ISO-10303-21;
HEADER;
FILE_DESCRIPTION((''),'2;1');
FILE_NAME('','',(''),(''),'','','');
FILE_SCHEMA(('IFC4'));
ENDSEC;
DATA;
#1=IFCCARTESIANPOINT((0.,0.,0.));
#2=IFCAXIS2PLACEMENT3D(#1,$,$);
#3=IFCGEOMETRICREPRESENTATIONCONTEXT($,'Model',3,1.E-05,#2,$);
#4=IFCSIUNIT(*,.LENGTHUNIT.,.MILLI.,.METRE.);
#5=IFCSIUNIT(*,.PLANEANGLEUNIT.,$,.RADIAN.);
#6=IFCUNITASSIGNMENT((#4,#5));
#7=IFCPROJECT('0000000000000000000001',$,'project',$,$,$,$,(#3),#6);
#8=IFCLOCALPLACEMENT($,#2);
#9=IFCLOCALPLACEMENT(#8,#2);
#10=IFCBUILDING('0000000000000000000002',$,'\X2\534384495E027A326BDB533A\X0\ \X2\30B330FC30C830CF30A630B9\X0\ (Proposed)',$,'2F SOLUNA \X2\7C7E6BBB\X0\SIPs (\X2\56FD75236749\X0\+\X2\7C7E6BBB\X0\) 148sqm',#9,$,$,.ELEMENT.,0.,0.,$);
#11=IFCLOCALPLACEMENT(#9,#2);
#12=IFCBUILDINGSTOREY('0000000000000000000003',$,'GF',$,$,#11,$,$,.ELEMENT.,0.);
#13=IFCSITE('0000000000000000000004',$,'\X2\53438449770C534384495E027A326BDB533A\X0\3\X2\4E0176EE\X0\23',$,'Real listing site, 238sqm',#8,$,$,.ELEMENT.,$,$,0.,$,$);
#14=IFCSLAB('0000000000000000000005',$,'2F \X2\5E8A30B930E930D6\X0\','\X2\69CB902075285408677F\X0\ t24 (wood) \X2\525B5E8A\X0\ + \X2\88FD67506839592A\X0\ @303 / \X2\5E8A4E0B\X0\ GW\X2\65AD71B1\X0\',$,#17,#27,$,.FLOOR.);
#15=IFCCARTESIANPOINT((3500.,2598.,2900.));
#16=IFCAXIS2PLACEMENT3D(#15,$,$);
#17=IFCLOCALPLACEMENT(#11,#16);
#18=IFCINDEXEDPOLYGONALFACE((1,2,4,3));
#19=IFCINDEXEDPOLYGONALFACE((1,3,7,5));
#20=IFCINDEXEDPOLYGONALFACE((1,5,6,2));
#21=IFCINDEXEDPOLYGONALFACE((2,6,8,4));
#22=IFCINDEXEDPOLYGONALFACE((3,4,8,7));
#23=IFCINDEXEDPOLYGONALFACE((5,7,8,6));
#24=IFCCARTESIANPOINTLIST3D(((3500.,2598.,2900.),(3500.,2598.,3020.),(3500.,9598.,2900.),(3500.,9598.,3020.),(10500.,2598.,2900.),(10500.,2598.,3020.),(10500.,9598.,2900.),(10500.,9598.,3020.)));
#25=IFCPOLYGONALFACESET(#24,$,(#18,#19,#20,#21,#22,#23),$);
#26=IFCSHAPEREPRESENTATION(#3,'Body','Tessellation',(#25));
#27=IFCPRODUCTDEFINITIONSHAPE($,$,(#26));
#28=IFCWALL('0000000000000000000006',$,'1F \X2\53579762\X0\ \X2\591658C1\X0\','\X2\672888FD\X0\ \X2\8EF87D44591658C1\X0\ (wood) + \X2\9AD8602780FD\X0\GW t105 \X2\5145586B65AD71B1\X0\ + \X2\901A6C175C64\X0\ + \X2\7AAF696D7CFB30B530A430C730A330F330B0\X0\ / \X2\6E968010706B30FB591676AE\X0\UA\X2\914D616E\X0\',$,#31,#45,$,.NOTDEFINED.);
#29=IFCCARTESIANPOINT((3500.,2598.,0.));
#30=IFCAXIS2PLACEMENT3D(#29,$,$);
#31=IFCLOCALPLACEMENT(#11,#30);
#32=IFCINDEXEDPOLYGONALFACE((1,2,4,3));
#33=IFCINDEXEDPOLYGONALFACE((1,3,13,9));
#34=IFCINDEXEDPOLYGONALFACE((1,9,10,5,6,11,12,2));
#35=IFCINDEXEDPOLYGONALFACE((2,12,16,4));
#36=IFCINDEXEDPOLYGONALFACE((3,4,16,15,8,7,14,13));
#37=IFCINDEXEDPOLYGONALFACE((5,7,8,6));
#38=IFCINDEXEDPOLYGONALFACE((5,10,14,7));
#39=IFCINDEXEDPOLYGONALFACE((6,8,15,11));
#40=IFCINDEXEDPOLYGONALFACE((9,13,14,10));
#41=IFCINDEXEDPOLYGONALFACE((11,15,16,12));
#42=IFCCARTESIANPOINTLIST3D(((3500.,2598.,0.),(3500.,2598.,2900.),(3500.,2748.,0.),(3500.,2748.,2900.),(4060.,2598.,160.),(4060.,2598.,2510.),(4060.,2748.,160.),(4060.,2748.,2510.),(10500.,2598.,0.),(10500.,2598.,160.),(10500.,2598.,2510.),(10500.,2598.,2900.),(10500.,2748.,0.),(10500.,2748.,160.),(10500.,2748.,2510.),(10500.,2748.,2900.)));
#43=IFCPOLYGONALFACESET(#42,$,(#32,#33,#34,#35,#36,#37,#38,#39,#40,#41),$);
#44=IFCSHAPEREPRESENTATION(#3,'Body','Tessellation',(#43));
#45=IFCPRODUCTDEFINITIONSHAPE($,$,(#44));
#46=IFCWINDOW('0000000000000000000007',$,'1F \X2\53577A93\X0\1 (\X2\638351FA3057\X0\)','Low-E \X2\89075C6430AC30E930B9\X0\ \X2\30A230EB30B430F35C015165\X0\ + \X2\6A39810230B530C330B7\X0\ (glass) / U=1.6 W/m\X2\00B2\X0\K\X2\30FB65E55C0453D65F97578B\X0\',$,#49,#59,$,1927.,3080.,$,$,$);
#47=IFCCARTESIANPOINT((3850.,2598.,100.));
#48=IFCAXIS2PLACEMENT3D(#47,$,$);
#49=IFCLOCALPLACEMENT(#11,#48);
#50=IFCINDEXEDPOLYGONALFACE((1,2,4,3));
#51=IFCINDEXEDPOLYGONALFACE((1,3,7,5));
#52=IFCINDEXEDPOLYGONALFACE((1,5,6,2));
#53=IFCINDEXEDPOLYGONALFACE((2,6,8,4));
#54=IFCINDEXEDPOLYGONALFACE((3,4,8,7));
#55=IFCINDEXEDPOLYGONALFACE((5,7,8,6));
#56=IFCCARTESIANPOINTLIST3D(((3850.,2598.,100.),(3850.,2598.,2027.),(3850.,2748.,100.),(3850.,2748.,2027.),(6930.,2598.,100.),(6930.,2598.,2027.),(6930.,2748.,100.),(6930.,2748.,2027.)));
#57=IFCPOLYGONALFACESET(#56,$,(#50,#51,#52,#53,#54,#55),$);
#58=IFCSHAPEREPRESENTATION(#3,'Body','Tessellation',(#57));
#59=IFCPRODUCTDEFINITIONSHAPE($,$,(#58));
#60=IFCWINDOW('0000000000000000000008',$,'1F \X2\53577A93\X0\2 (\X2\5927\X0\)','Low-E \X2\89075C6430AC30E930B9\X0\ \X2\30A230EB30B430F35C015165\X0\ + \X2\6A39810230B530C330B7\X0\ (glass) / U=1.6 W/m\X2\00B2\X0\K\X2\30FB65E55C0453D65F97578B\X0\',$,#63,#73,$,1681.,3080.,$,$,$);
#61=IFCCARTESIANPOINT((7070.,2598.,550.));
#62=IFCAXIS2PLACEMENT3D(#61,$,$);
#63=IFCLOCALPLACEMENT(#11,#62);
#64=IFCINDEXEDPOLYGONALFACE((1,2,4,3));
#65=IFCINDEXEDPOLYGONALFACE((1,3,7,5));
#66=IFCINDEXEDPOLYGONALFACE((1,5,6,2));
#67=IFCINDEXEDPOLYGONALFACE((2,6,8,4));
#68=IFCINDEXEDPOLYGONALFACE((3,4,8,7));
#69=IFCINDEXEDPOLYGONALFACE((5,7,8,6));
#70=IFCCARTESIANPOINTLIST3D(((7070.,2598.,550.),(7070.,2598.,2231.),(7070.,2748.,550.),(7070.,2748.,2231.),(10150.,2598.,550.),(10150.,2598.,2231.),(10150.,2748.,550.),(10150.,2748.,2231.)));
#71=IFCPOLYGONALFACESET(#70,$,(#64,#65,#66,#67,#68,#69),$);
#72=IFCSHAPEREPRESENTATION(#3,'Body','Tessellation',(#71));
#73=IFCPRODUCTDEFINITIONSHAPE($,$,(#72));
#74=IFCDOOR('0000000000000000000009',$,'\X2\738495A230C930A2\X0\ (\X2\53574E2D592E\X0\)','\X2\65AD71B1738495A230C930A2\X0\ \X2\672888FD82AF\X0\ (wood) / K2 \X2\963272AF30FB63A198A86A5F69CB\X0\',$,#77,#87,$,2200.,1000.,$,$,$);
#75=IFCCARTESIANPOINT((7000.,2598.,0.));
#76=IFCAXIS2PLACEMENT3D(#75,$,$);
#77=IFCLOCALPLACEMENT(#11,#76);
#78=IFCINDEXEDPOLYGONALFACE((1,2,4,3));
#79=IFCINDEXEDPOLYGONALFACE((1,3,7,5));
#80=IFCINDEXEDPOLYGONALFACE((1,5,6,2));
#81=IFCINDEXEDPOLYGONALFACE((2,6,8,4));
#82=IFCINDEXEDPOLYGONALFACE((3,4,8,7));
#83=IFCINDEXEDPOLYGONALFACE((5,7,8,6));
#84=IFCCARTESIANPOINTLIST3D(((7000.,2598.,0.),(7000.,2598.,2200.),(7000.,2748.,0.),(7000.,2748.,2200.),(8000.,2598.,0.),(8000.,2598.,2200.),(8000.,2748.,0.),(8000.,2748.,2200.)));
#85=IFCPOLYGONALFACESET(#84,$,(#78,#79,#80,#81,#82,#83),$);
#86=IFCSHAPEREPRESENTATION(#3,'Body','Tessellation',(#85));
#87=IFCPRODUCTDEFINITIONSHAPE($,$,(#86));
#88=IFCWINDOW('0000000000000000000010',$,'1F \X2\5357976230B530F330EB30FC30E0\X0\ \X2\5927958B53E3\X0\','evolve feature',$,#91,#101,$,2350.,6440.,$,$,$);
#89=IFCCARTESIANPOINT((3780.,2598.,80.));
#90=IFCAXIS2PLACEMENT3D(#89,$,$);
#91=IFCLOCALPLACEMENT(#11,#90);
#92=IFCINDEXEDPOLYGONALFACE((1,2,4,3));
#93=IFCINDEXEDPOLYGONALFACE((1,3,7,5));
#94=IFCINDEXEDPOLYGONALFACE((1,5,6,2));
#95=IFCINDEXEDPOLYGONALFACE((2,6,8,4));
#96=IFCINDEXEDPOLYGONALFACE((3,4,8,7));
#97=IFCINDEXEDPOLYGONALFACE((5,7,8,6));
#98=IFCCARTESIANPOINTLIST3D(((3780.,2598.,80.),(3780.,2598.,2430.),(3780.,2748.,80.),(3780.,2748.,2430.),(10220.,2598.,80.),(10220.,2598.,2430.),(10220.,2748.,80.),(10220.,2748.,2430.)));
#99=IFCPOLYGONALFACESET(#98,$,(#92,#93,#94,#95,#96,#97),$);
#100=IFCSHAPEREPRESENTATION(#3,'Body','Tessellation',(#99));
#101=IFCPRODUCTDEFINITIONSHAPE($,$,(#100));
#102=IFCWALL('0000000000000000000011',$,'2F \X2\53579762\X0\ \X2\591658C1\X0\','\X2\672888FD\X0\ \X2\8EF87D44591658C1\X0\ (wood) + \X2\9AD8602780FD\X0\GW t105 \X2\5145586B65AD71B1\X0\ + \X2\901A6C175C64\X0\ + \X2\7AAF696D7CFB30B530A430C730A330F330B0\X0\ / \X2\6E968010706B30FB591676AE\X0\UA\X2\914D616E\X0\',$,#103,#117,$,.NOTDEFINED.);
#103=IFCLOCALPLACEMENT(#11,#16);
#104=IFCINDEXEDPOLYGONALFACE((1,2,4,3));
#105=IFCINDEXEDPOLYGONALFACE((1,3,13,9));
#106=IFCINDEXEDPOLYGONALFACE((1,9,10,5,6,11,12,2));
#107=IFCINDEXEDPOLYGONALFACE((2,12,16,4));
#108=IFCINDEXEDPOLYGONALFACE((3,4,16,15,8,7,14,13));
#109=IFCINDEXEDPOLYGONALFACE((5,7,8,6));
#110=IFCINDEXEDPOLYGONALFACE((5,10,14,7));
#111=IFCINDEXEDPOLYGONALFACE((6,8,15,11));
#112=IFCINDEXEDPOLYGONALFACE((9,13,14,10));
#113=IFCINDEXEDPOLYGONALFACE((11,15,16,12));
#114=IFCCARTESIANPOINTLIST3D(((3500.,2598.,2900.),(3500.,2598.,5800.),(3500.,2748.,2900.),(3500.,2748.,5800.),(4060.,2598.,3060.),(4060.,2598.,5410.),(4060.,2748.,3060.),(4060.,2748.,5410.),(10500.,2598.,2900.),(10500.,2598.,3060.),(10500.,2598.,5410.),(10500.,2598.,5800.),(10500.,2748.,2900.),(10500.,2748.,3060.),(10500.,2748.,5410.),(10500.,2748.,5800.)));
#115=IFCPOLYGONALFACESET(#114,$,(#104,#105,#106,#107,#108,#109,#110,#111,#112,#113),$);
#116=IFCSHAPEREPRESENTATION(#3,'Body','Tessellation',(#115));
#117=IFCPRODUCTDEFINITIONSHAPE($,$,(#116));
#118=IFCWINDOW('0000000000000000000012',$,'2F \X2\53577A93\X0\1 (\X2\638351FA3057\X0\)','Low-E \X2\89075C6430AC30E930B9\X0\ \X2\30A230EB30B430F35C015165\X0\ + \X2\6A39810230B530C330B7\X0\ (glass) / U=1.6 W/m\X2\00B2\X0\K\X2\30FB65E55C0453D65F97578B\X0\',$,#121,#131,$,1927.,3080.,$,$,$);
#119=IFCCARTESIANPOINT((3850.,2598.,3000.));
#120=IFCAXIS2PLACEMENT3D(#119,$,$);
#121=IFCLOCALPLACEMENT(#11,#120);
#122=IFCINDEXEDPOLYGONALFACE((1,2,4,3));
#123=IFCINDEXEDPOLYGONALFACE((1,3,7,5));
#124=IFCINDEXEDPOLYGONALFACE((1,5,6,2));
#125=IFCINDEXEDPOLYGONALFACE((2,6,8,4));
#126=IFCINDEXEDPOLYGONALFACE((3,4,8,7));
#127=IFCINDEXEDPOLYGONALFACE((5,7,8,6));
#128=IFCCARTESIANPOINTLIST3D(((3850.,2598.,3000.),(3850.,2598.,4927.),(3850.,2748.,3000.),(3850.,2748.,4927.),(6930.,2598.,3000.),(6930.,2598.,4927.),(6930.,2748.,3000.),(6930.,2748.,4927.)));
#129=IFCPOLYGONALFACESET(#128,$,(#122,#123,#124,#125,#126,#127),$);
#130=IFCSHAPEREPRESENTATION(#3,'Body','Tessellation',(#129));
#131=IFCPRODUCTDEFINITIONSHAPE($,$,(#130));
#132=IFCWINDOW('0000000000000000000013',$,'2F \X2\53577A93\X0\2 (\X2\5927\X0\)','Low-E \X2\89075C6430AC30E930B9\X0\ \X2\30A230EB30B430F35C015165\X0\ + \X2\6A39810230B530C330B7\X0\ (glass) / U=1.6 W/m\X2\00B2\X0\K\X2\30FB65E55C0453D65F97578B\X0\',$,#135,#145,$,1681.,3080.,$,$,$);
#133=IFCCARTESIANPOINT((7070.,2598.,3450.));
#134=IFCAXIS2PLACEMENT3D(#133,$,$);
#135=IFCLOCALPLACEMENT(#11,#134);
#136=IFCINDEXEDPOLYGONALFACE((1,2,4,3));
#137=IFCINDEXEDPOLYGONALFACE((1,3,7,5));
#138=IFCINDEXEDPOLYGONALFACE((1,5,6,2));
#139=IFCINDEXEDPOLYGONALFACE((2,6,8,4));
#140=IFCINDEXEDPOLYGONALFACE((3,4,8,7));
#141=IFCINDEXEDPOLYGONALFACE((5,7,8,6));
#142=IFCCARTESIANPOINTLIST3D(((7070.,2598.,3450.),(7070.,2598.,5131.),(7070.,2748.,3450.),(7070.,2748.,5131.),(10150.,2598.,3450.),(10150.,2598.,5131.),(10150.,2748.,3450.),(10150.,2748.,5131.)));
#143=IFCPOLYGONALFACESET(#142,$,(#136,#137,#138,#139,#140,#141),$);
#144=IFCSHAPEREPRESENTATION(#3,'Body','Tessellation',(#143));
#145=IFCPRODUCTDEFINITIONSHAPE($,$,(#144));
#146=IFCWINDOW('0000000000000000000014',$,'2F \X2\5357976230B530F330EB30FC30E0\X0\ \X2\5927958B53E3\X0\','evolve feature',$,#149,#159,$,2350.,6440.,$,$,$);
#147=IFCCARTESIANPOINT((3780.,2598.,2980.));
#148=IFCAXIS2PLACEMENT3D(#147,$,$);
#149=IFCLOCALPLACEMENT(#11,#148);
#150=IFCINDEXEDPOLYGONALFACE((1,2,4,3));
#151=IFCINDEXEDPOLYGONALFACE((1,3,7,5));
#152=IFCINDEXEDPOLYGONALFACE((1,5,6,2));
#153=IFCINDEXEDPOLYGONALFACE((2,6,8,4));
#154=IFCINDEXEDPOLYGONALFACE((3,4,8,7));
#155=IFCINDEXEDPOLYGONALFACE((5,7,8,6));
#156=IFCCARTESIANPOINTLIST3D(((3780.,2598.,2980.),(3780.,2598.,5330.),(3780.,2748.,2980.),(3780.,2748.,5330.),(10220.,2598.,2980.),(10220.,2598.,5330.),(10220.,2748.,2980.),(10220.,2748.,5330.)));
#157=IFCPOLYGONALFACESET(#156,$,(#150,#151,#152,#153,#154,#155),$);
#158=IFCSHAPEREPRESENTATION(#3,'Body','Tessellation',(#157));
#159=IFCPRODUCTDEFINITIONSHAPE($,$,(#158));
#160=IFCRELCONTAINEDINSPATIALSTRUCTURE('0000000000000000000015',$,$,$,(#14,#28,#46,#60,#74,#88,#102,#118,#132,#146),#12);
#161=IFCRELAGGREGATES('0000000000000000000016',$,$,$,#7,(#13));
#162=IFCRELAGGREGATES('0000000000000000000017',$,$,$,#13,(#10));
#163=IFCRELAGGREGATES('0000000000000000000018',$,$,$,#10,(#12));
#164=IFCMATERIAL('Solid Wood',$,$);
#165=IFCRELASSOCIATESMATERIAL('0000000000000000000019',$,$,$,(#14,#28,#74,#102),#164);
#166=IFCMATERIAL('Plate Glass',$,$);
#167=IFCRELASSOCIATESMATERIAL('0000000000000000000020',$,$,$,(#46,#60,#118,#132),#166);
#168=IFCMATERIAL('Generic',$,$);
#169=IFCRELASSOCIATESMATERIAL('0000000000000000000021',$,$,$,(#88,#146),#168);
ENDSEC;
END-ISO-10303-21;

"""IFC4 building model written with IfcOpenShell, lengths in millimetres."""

from ifc_helpers import new_model, si_unit, frame, frame_2d, origin, place, context, project, spatial, rectangle, extrude, material, element, fill, save


model = new_model("IFC4")

# Units and contexts
model_context = context("Model", 3, precision=1e-05, world=origin())
ifc_project = project(units=[si_unit("LENGTHUNIT", "METRE", prefix="MILLI"), si_unit("PLANEANGLEUNIT", "RADIAN")], contexts=[model_context])

# Site, building, storey
site_placement = place(None, origin())
site = spatial("IfcSite", under=ifc_project, at=site_placement, Name="千葉県千葉市稲毛区3丁目23", ObjectType="Real listing site, 238sqm", CompositionType="ELEMENT", RefElevation=0.0)
building_placement = place(site_placement, origin())
building = spatial("IfcBuilding", under=site, at=building_placement, Name="千葉市稲毛区 コートハウス (Proposed)", ObjectType="2F SOLUNA 籾殻SIPs (国産杉+籾殻) 148sqm", CompositionType="ELEMENT", ElevationOfRefHeight=0.0, ElevationOfTerrain=0.0)
storey_placement = place(building_placement, origin())
storey = spatial("IfcBuildingStorey", under=building, at=storey_placement, Name="GF", CompositionType="ELEMENT", Elevation=0.0)

# Slab
ifc_material_1 = material(Name="Solid Wood")
slab_1_placement = place(storey_placement, frame((3500.0, 2598.0, 2900.0)))
element("IfcSlab", 1, at=slab_1_placement, inside=storey, material=ifc_material_1, Name="2F 床スラブ", Description="構造用合板 t24 (wood) 剛床 + 製材根太 @303 / 床下 GW断熱", PredefinedType="FLOOR", context=model_context, shape_type="SweptSolid", body=[
    extrude(rectangle(XDim=7000.0, YDim=7000.0, at=frame_2d((3500.0, 3500.0))), frame((3500.0, 2598.0, 2900.0)), (0.0, 0.0, 1.0), 120.0),
])
ifc_material_2 = material(Name="Generic")

# Wall, openings, windows, door
wall_1_placement = place(storey_placement, frame((3500.0, 2598.0, 0.0)))
wall_1 = element("IfcWall", 2, at=wall_1_placement, inside=storey, material=ifc_material_1, Name="1F 南面 外壁", Description="木製 軸組外壁 (wood) + 高性能GW t105 充填断熱 + 通気層 + 窯業系サイディング / 準耐火・外皮UA配慮", PredefinedType="NOTDEFINED", context=model_context, shape_type="SweptSolid", body=[
    extrude(rectangle(XDim=7000.0, YDim=150.0, at=frame_2d((3500.0, 75.0))), frame((3500.0, 2598.0, 0.0)), (0.0, 0.0, 1.0), 2900.0),
])
opening_1_placement = place(storey_placement, frame((3850.0, 2598.0, 100.0)))
opening_1 = element("IfcOpeningElement", 3, at=opening_1_placement, cuts=wall_1, PredefinedType="NOTDEFINED", context=model_context, shape_type="SweptSolid", body=[
    extrude(rectangle(XDim=3080.0, YDim=150.0, at=frame_2d((1540.0, 75.0))), frame((3850.0, 2598.0, 100.0)), (0.0, 0.0, 1.0), 1927.0),
])
opening_2_placement = place(storey_placement, frame((7070.0, 2598.0, 550.0)))
opening_2 = element("IfcOpeningElement", 4, at=opening_2_placement, cuts=wall_1, PredefinedType="NOTDEFINED", context=model_context, shape_type="SweptSolid", body=[
    extrude(rectangle(XDim=3080.0, YDim=150.0, at=frame_2d((1540.0, 75.0))), frame((7070.0, 2598.0, 550.0)), (0.0, 0.0, 1.0), 1681.0),
])
opening_3_placement = place(storey_placement, frame((7000.0, 2598.0, 0.0)))
opening_3 = element("IfcOpeningElement", 5, at=opening_3_placement, cuts=wall_1, PredefinedType="NOTDEFINED", context=model_context, shape_type="SweptSolid", body=[
    extrude(rectangle(XDim=1000.0, YDim=150.0, at=frame_2d((500.0, 75.0))), frame((7000.0, 2598.0, 0.0)), (0.0, 0.0, 1.0), 2200.0),
])
opening_4_placement = place(storey_placement, frame((3780.0, 2598.0, 80.0)))
opening_4 = element("IfcOpeningElement", 6, at=opening_4_placement, cuts=wall_1, PredefinedType="NOTDEFINED", context=model_context, shape_type="SweptSolid", body=[
    extrude(rectangle(XDim=6440.0, YDim=150.0, at=frame_2d((3220.0, 75.0))), frame((3780.0, 2598.0, 80.0)), (0.0, 0.0, 1.0), 2350.0),
])
ifc_material_3 = material(Name="Plate Glass")
window_1_placement = place(storey_placement, frame((3850.0, 2598.0, 100.0)))
window_1 = element("IfcWindow", 7, at=window_1_placement, inside=storey, material=ifc_material_3, Name="1F 南窓1 (掃出し)", Description="Low-E 複層ガラス アルゴン封入 + 樹脂サッシ (glass) / U=1.6 W/m²K・日射取得型", OverallHeight=1927.0, OverallWidth=3080.0, context=model_context, shape_type="SweptSolid", body=[
    extrude(rectangle(XDim=3080.0, YDim=150.0, at=frame_2d((1540.0, 75.0))), frame((3850.0, 2598.0, 100.0)), (0.0, 0.0, 1.0), 1927.0),
])
fill(opening_1, window_1)
window_2_placement = place(storey_placement, frame((7070.0, 2598.0, 550.0)))
window_2 = element("IfcWindow", 8, at=window_2_placement, inside=storey, material=ifc_material_3, Name="1F 南窓2 (大)", Description="Low-E 複層ガラス アルゴン封入 + 樹脂サッシ (glass) / U=1.6 W/m²K・日射取得型", OverallHeight=1681.0, OverallWidth=3080.0, context=model_context, shape_type="SweptSolid", body=[
    extrude(rectangle(XDim=3080.0, YDim=150.0, at=frame_2d((1540.0, 75.0))), frame((7070.0, 2598.0, 550.0)), (0.0, 0.0, 1.0), 1681.0),
])
fill(opening_2, window_2)
door_placement = place(storey_placement, frame((7000.0, 2598.0, 0.0)))
door = element("IfcDoor", 9, at=door_placement, inside=storey, material=ifc_material_1, Name="玄関ドア (南中央)", Description="断熱玄関ドア 木製芯 (wood) / K2 防犯・採風機構", OverallHeight=2200.0, OverallWidth=1000.0, context=model_context, shape_type="SweptSolid", body=[
    extrude(rectangle(XDim=1000.0, YDim=150.0, at=frame_2d((500.0, 75.0))), frame((7000.0, 2598.0, 0.0)), (0.0, 0.0, 1.0), 2200.0),
])
fill(opening_3, door)
window_3_placement = place(storey_placement, frame((3780.0, 2598.0, 80.0)))
window_3 = element("IfcWindow", 10, at=window_3_placement, inside=storey, material=ifc_material_2, Name="1F 南面サンルーム 大開口", Description="evolve feature", OverallHeight=2350.0, OverallWidth=6440.0, context=model_context, shape_type="SweptSolid", body=[
    extrude(rectangle(XDim=6440.0, YDim=150.0, at=frame_2d((3220.0, 75.0))), frame((3780.0, 2598.0, 80.0)), (0.0, 0.0, 1.0), 2350.0),
])
fill(opening_4, window_3)

# Wall, openings, windows
wall_2_placement = place(storey_placement, frame((3500.0, 2598.0, 2900.0)))
wall_2 = element("IfcWall", 11, at=wall_2_placement, inside=storey, material=ifc_material_1, Name="2F 南面 外壁", Description="木製 軸組外壁 (wood) + 高性能GW t105 充填断熱 + 通気層 + 窯業系サイディング / 準耐火・外皮UA配慮", PredefinedType="NOTDEFINED", context=model_context, shape_type="SweptSolid", body=[
    extrude(rectangle(XDim=7000.0, YDim=150.0, at=frame_2d((3500.0, 75.0))), frame((3500.0, 2598.0, 2900.0)), (0.0, 0.0, 1.0), 2900.0),
])
opening_5_placement = place(storey_placement, frame((3850.0, 2598.0, 3000.0)))
opening_5 = element("IfcOpeningElement", 12, at=opening_5_placement, cuts=wall_2, PredefinedType="NOTDEFINED", context=model_context, shape_type="SweptSolid", body=[
    extrude(rectangle(XDim=3080.0, YDim=150.0, at=frame_2d((1540.0, 75.0))), frame((3850.0, 2598.0, 3000.0)), (0.0, 0.0, 1.0), 1927.0),
])
opening_6_placement = place(storey_placement, frame((7070.0, 2598.0, 3450.0)))
opening_6 = element("IfcOpeningElement", 13, at=opening_6_placement, cuts=wall_2, PredefinedType="NOTDEFINED", context=model_context, shape_type="SweptSolid", body=[
    extrude(rectangle(XDim=3080.0, YDim=150.0, at=frame_2d((1540.0, 75.0))), frame((7070.0, 2598.0, 3450.0)), (0.0, 0.0, 1.0), 1681.0),
])
opening_7_placement = place(storey_placement, frame((3780.0, 2598.0, 2980.0)))
opening_7 = element("IfcOpeningElement", 14, at=opening_7_placement, cuts=wall_2, PredefinedType="NOTDEFINED", context=model_context, shape_type="SweptSolid", body=[
    extrude(rectangle(XDim=6440.0, YDim=150.0, at=frame_2d((3220.0, 75.0))), frame((3780.0, 2598.0, 2980.0)), (0.0, 0.0, 1.0), 2350.0),
])
window_4_placement = place(storey_placement, frame((3850.0, 2598.0, 3000.0)))
window_4 = element("IfcWindow", 15, at=window_4_placement, inside=storey, material=ifc_material_3, Name="2F 南窓1 (掃出し)", Description="Low-E 複層ガラス アルゴン封入 + 樹脂サッシ (glass) / U=1.6 W/m²K・日射取得型", OverallHeight=1927.0, OverallWidth=3080.0, context=model_context, shape_type="SweptSolid", body=[
    extrude(rectangle(XDim=3080.0, YDim=150.0, at=frame_2d((1540.0, 75.0))), frame((3850.0, 2598.0, 3000.0)), (0.0, 0.0, 1.0), 1927.0),
])
fill(opening_5, window_4)
window_5_placement = place(storey_placement, frame((7070.0, 2598.0, 3450.0)))
window_5 = element("IfcWindow", 16, at=window_5_placement, inside=storey, material=ifc_material_3, Name="2F 南窓2 (大)", Description="Low-E 複層ガラス アルゴン封入 + 樹脂サッシ (glass) / U=1.6 W/m²K・日射取得型", OverallHeight=1681.0, OverallWidth=3080.0, context=model_context, shape_type="SweptSolid", body=[
    extrude(rectangle(XDim=3080.0, YDim=150.0, at=frame_2d((1540.0, 75.0))), frame((7070.0, 2598.0, 3450.0)), (0.0, 0.0, 1.0), 1681.0),
])
fill(opening_6, window_5)
window_6_placement = place(storey_placement, frame((3780.0, 2598.0, 2980.0)))
window_6 = element("IfcWindow", 17, at=window_6_placement, inside=storey, material=ifc_material_2, Name="2F 南面サンルーム 大開口", Description="evolve feature", OverallHeight=2350.0, OverallWidth=6440.0, context=model_context, shape_type="SweptSolid", body=[
    extrude(rectangle(XDim=6440.0, YDim=150.0, at=frame_2d((3220.0, 75.0))), frame((3780.0, 2598.0, 2980.0)), (0.0, 0.0, 1.0), 2350.0),
])
fill(opening_7, window_6)

save(model, "model.ifc")
